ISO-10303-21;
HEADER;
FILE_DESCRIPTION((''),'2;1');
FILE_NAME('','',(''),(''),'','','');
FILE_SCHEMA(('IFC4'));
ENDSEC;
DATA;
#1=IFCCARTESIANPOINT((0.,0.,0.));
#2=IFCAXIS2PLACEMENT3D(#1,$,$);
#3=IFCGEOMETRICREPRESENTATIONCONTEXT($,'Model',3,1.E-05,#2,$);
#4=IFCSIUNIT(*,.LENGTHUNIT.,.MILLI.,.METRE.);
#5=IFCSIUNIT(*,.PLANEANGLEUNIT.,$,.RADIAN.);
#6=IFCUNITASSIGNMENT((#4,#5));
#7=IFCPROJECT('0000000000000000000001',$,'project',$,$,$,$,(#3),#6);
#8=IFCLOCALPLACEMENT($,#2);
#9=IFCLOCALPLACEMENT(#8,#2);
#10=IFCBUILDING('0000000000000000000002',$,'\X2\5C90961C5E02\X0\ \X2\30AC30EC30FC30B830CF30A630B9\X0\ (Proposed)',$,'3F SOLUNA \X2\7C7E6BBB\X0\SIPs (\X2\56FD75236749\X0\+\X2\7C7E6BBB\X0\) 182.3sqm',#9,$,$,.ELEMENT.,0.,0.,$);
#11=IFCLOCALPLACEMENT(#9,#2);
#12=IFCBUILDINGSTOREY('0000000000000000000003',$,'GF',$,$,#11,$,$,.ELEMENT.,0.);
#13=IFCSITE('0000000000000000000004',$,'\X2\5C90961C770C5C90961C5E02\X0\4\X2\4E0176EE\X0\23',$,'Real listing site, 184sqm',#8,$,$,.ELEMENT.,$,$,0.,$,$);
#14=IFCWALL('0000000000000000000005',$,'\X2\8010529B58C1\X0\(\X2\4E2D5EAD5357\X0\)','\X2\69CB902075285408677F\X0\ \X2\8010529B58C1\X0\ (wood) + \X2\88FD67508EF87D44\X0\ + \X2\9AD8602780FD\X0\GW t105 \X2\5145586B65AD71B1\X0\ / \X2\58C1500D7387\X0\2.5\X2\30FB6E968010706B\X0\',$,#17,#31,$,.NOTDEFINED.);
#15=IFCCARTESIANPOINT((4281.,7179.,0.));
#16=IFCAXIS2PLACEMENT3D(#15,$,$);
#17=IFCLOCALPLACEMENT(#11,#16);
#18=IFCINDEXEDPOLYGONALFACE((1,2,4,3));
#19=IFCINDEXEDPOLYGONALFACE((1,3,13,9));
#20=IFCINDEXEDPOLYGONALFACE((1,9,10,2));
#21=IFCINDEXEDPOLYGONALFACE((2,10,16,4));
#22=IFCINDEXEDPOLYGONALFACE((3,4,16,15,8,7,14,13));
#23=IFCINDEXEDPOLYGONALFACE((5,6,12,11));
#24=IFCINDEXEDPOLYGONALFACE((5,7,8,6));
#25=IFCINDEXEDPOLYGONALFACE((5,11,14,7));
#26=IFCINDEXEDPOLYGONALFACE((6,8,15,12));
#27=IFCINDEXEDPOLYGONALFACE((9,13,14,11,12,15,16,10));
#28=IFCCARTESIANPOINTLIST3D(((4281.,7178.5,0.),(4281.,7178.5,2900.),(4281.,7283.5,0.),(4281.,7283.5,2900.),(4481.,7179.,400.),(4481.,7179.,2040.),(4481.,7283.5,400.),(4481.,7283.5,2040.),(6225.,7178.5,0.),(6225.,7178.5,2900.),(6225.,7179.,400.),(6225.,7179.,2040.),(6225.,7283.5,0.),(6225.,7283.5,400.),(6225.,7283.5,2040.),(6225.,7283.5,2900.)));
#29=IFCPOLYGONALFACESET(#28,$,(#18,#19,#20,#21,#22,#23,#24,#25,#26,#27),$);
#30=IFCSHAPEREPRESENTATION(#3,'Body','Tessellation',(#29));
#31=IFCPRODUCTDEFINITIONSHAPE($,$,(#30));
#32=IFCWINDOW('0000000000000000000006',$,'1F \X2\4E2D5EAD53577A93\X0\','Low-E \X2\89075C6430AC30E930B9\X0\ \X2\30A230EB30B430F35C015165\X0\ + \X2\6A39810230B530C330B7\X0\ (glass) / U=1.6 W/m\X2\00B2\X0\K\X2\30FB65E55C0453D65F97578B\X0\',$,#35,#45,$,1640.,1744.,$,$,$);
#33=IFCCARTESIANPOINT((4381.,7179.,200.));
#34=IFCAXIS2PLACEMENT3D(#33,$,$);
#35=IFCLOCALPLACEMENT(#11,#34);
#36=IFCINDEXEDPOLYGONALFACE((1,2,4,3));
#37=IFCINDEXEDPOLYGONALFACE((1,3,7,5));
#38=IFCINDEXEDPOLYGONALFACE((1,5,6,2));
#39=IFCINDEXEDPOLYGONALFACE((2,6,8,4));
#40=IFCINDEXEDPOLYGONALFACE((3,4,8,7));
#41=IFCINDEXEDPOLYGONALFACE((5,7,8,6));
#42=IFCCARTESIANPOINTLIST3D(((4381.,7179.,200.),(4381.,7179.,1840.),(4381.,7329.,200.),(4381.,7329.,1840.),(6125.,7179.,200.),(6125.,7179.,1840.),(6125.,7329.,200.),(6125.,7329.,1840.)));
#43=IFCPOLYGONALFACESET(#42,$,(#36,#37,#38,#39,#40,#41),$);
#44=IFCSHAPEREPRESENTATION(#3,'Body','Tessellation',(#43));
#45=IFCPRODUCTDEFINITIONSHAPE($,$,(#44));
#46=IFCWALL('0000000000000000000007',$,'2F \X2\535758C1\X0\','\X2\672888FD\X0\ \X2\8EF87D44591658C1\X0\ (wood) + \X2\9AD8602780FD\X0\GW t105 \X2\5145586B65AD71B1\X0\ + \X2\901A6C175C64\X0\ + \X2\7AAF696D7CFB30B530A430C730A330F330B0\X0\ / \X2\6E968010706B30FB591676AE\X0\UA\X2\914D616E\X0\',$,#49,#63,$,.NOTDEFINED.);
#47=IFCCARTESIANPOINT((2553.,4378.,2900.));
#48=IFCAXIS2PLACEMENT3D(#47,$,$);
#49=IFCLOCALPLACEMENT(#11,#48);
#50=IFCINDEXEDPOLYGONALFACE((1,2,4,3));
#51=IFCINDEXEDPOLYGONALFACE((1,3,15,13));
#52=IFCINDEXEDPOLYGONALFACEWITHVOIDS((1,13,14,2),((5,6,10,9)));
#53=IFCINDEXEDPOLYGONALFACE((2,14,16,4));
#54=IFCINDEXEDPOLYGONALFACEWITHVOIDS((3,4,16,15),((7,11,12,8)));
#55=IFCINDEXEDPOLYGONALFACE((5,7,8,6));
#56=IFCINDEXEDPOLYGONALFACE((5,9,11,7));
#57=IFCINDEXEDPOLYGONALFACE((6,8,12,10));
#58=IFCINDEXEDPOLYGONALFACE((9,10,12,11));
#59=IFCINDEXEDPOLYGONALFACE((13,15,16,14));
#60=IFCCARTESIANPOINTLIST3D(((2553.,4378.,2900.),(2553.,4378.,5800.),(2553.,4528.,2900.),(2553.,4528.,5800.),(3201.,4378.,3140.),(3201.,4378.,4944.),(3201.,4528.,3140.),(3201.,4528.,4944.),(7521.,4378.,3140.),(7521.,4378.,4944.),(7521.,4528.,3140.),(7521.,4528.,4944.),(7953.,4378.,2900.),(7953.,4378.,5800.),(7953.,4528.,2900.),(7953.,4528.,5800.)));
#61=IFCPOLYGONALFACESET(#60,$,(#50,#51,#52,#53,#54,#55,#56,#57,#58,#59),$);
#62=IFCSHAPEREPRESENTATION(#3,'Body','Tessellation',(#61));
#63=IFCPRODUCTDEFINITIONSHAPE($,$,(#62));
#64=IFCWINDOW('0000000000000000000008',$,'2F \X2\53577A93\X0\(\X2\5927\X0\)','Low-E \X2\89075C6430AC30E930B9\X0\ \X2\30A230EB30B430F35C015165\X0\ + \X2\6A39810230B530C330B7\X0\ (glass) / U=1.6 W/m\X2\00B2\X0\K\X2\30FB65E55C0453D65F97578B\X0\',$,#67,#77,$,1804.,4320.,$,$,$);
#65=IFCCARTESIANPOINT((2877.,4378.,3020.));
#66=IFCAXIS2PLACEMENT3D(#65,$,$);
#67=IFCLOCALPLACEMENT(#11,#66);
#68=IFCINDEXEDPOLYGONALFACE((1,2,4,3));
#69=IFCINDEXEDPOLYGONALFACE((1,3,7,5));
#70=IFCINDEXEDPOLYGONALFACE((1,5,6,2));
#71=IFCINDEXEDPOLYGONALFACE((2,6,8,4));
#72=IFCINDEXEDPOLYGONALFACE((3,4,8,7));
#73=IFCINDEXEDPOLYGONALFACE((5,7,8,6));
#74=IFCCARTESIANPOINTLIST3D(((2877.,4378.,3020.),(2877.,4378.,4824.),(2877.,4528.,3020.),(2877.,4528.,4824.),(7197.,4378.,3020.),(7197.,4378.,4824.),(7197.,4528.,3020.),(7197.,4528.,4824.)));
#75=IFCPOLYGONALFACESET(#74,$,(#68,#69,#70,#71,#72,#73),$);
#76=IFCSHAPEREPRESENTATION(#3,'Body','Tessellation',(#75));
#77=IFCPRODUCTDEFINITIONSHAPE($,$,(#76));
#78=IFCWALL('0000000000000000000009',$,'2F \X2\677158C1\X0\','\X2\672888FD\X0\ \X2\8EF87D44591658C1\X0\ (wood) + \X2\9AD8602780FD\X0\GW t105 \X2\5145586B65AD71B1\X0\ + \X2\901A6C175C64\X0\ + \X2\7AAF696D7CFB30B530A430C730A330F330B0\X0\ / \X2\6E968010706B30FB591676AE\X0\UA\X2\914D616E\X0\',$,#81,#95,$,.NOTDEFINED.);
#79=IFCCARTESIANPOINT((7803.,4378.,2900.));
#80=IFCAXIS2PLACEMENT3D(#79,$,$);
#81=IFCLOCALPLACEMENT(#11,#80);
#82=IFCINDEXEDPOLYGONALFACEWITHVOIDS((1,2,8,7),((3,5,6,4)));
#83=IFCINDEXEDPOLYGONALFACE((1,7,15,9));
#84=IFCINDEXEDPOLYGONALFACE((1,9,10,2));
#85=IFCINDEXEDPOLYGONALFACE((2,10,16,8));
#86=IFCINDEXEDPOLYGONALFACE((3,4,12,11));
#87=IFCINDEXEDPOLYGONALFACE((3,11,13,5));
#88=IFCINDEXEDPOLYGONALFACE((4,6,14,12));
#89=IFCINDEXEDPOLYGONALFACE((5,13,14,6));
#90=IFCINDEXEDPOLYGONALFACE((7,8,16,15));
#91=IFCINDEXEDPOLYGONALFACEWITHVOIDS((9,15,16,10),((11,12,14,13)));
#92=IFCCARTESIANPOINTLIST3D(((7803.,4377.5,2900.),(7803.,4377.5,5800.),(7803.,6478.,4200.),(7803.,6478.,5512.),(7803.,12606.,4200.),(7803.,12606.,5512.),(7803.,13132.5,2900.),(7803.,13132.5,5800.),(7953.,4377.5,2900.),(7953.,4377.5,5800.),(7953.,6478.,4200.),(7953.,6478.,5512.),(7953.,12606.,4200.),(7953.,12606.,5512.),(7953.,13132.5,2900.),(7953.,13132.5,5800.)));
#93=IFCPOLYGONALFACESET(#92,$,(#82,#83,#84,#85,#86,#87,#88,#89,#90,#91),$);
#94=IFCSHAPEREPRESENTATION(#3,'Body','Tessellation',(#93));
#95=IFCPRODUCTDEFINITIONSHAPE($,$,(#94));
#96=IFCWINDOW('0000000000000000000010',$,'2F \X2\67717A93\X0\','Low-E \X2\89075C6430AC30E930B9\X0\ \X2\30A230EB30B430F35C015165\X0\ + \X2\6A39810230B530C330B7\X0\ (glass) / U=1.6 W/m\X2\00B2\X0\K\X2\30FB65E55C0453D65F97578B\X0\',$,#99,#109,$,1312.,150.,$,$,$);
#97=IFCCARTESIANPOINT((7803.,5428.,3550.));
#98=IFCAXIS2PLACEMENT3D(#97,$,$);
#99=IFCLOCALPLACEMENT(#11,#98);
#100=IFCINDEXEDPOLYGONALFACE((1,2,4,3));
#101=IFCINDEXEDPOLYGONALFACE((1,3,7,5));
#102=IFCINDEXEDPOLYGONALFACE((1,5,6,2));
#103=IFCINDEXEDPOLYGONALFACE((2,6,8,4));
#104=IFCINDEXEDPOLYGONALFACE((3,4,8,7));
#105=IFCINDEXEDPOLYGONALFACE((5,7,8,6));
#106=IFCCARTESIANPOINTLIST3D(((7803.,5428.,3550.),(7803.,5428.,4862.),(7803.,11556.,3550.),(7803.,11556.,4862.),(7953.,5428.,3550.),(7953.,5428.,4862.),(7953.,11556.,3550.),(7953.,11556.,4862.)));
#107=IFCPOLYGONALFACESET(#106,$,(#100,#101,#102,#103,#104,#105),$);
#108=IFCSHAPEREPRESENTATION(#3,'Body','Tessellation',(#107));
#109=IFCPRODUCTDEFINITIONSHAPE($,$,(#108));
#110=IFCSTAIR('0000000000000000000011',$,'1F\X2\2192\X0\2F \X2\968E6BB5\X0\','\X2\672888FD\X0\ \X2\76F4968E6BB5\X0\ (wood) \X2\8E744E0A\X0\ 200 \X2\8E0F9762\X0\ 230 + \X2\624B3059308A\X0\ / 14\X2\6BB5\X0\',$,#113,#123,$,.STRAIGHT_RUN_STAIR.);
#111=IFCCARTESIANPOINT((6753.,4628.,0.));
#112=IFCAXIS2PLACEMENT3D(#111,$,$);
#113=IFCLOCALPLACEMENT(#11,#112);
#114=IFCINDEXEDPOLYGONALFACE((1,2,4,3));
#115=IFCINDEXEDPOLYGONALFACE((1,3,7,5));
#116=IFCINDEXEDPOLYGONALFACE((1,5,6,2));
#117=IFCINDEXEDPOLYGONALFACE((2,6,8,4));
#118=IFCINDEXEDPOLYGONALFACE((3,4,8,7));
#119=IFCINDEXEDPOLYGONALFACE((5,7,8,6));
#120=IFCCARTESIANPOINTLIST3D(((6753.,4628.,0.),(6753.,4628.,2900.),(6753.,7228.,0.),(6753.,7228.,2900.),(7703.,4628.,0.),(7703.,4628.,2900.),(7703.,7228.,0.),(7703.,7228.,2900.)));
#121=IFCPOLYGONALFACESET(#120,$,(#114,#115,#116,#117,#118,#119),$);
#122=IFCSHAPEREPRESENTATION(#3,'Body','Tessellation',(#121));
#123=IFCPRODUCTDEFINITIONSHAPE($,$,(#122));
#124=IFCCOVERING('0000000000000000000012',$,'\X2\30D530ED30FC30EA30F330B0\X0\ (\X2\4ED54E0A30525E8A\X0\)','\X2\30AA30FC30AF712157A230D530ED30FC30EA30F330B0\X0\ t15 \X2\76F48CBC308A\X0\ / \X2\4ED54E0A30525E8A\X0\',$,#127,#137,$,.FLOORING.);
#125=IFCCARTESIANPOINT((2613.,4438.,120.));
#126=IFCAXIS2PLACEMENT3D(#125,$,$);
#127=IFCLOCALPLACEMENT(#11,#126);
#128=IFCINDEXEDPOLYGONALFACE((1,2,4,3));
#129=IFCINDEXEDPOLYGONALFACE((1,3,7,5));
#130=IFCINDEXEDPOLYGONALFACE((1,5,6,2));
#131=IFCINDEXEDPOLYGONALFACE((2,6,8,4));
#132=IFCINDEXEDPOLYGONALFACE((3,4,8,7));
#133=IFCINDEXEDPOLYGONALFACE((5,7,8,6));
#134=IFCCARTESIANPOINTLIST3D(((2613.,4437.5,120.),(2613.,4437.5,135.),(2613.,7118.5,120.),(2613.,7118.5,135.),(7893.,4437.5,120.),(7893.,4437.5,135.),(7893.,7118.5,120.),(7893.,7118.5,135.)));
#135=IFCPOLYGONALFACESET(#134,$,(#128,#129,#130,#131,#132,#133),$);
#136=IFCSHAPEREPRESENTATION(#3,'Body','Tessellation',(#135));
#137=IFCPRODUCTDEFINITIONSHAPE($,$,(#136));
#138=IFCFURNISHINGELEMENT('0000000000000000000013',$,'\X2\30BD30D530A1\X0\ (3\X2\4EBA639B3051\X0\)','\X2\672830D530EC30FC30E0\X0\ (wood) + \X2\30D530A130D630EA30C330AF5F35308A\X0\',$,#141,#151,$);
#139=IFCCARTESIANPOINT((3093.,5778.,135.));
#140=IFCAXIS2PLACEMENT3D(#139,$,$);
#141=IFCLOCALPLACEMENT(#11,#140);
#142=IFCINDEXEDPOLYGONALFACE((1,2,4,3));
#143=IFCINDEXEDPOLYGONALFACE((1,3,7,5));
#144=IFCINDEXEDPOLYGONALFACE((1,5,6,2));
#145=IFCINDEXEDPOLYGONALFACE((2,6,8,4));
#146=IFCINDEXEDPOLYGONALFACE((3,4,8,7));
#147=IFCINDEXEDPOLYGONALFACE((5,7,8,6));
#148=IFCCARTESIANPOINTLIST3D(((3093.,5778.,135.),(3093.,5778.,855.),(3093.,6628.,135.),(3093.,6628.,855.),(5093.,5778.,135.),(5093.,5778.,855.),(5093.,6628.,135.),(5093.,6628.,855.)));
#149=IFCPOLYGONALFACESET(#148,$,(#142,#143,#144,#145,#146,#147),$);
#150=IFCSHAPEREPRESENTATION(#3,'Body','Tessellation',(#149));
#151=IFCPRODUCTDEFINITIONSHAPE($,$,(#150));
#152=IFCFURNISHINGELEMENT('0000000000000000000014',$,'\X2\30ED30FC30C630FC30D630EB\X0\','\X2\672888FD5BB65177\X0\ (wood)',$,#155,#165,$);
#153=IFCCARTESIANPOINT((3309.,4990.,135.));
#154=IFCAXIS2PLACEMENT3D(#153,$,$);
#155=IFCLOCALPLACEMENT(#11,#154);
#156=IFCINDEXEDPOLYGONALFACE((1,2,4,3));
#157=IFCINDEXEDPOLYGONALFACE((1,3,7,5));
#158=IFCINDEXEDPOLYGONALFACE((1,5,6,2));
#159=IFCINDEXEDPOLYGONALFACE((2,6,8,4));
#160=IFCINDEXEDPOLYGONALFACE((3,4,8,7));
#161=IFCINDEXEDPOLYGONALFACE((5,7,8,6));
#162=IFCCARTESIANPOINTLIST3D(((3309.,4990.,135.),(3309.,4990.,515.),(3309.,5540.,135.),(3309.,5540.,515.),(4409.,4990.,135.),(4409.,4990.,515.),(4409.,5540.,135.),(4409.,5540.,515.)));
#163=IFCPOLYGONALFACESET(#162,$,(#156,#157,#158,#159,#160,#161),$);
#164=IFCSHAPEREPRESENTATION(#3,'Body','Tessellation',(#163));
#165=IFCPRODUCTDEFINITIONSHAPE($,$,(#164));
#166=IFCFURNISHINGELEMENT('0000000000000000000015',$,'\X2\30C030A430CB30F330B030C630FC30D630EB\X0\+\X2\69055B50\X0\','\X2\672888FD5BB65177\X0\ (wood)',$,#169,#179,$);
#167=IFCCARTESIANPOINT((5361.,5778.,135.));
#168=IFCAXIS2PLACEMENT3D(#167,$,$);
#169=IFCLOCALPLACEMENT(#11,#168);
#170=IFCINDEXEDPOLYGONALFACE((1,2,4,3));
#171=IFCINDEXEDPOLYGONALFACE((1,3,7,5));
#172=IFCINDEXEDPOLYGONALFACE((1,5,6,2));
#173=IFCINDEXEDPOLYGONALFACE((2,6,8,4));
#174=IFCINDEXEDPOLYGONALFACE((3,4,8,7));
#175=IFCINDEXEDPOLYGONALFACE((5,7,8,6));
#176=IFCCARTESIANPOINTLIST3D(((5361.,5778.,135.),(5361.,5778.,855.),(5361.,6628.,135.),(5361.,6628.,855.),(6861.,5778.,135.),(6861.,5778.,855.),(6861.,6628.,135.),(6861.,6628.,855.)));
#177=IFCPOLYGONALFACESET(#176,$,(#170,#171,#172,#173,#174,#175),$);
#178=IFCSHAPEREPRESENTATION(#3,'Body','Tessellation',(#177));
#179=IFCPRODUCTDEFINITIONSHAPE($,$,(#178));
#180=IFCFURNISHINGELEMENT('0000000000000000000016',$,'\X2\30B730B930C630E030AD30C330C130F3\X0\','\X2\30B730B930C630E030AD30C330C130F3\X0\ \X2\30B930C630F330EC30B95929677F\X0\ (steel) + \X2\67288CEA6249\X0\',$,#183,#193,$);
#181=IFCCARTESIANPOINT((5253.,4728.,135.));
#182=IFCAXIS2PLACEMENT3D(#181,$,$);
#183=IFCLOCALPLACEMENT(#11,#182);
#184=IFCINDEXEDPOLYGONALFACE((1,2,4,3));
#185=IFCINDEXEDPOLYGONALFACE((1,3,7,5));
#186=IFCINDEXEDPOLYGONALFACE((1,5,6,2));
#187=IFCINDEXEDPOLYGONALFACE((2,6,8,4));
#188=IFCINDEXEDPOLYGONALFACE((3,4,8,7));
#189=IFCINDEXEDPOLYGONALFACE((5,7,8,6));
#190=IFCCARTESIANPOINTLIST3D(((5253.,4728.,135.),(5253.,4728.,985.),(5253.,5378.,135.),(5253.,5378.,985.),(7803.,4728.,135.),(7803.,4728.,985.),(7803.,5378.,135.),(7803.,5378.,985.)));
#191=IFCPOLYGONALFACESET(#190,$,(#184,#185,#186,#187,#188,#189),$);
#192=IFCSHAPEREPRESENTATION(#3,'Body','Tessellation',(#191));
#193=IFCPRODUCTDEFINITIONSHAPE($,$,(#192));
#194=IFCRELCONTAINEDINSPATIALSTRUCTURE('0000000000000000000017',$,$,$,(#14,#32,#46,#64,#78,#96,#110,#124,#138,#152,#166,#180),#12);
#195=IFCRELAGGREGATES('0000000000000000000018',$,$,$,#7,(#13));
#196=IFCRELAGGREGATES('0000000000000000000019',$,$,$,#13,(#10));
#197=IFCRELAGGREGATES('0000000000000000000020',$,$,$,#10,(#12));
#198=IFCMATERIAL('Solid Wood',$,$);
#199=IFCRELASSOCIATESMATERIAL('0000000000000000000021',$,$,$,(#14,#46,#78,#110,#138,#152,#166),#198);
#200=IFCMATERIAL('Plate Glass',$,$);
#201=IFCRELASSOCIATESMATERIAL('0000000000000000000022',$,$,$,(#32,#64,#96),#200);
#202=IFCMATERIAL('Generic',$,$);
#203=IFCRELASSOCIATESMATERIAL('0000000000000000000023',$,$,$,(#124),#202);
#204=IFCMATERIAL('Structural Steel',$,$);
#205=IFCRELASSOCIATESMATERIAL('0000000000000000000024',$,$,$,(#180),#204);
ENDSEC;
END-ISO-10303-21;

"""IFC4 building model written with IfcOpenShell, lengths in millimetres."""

from ifc_helpers import new_model, si_unit, frame, frame_2d, origin, place, context, project, spatial, rectangle, extrude, material, element, fill, save


model = new_model("IFC4")

# Units and contexts
model_context = context("Model", 3, precision=1e-05, world=origin())
ifc_project = project(units=[si_unit("LENGTHUNIT", "METRE", prefix="MILLI"), si_unit("PLANEANGLEUNIT", "RADIAN")], contexts=[model_context])

# Site, building, storey
site_placement = place(None, origin())
site = spatial("IfcSite", under=ifc_project, at=site_placement, Name="岐阜県岐阜市4丁目23", ObjectType="Real listing site, 184sqm", CompositionType="ELEMENT", RefElevation=0.0)
building_placement = place(site_placement, origin())
building = spatial("IfcBuilding", under=site, at=building_placement, Name="岐阜市 ガレージハウス (Proposed)", ObjectType="3F SOLUNA 籾殻SIPs (国産杉+籾殻) 182.3sqm", CompositionType="ELEMENT", ElevationOfRefHeight=0.0, ElevationOfTerrain=0.0)
storey_placement = place(building_placement, origin())
storey = spatial("IfcBuildingStorey", under=building, at=storey_placement, Name="GF", CompositionType="ELEMENT", Elevation=0.0)

# Shared definitions
ifc_material_1 = material(Name="Solid Wood")
ifc_material_2 = material(Name="Generic")

# Shared definitions
ifc_material_3 = material(Name="Plate Glass")

# Wall, opening, window
wall_1_placement = place(storey_placement, frame((4281.0, 7179.0, 0.0)))
wall_1 = element("IfcWall", 1, at=wall_1_placement, inside=storey, material=ifc_material_1, Name="耐力壁(中庭南)", Description="構造用合板 耐力壁 (wood) + 製材軸組 + 高性能GW t105 充填断熱 / 壁倍率2.5・準耐火", PredefinedType="NOTDEFINED", context=model_context, shape_type="SweptSolid", body=[
    extrude(rectangle(XDim=1944.0, YDim=105.0, at=frame_2d((972.0, 52.0))), frame((4281.0, 7179.0, 0.0)), (0.0, 0.0, 1.0), 2900.0),
])
opening_1_placement = place(storey_placement, frame((4381.0, 7179.0, 200.0)))
opening_1 = element("IfcOpeningElement", 2, at=opening_1_placement, cuts=wall_1, PredefinedType="NOTDEFINED", context=model_context, shape_type="SweptSolid", body=[
    extrude(rectangle(XDim=1744.0, YDim=150.0, at=frame_2d((872.0, 75.0))), frame((4381.0, 7179.0, 200.0)), (0.0, 0.0, 1.0), 1640.0),
])
window_1_placement = place(storey_placement, frame((4381.0, 7179.0, 200.0)))
window_1 = element("IfcWindow", 3, at=window_1_placement, inside=storey, material=ifc_material_3, Name="1F 中庭南窓", Description="Low-E 複層ガラス アルゴン封入 + 樹脂サッシ (glass) / U=1.6 W/m²K・日射取得型", OverallHeight=1640.0, OverallWidth=1744.0, context=model_context, shape_type="SweptSolid", body=[
    extrude(rectangle(XDim=1744.0, YDim=150.0, at=frame_2d((872.0, 75.0))), frame((4381.0, 7179.0, 200.0)), (0.0, 0.0, 1.0), 1640.0),
])
fill(opening_1, window_1)

# Walls, openings, windows
wall_2_placement = place(storey_placement, frame((2553.0, 4378.0, 2900.0)))
wall_2 = element("IfcWall", 4, at=wall_2_placement, inside=storey, material=ifc_material_1, Name="2F 南壁", Description="木製 軸組外壁 (wood) + 高性能GW t105 充填断熱 + 通気層 + 窯業系サイディング / 準耐火・外皮UA配慮", PredefinedType="NOTDEFINED", context=model_context, shape_type="SweptSolid", body=[
    extrude(rectangle(XDim=5400.0, YDim=150.0, at=frame_2d((2700.0, 75.0))), frame((2553.0, 4378.0, 2900.0)), (0.0, 0.0, 1.0), 2900.0),
])
opening_2_placement = place(storey_placement, frame((2877.0, 4378.0, 3020.0)))
opening_2 = element("IfcOpeningElement", 5, at=opening_2_placement, cuts=wall_2, PredefinedType="NOTDEFINED", context=model_context, shape_type="SweptSolid", body=[
    extrude(rectangle(XDim=4320.0, YDim=150.0, at=frame_2d((2160.0, 75.0))), frame((2877.0, 4378.0, 3020.0)), (0.0, 0.0, 1.0), 1804.0),
])
window_2_placement = place(storey_placement, frame((2877.0, 4378.0, 3020.0)))
window_2 = element("IfcWindow", 6, at=window_2_placement, inside=storey, material=ifc_material_3, Name="2F 南窓(大)", Description="Low-E 複層ガラス アルゴン封入 + 樹脂サッシ (glass) / U=1.6 W/m²K・日射取得型", OverallHeight=1804.0, OverallWidth=4320.0, context=model_context, shape_type="SweptSolid", body=[
    extrude(rectangle(XDim=4320.0, YDim=150.0, at=frame_2d((2160.0, 75.0))), frame((2877.0, 4378.0, 3020.0)), (0.0, 0.0, 1.0), 1804.0),
])
fill(opening_2, window_2)
wall_3_placement = place(storey_placement, frame((7803.0, 4378.0, 2900.0)))
wall_3 = element("IfcWall", 7, at=wall_3_placement, inside=storey, material=ifc_material_1, Name="2F 東壁", Description="木製 軸組外壁 (wood) + 高性能GW t105 充填断熱 + 通気層 + 窯業系サイディング / 準耐火・外皮UA配慮", PredefinedType="NOTDEFINED", context=model_context, shape_type="SweptSolid", body=[
    extrude(rectangle(XDim=150.0, YDim=8755.0, at=frame_2d((75.0, 4377.0))), frame((7803.0, 4378.0, 2900.0)), (0.0, 0.0, 1.0), 2900.0),
])
opening_3_placement = place(storey_placement, frame((7803.0, 5428.0, 3550.0)))
opening_3 = element("IfcOpeningElement", 8, at=opening_3_placement, cuts=wall_3, PredefinedType="NOTDEFINED", context=model_context, shape_type="SweptSolid", body=[
    extrude(rectangle(XDim=150.0, YDim=6128.0, at=frame_2d((75.0, 3064.0))), frame((7803.0, 5428.0, 3550.0)), (0.0, 0.0, 1.0), 1312.0),
])
window_3_placement = place(storey_placement, frame((7803.0, 5428.0, 3550.0)))
window_3 = element("IfcWindow", 9, at=window_3_placement, inside=storey, material=ifc_material_3, Name="2F 東窓", Description="Low-E 複層ガラス アルゴン封入 + 樹脂サッシ (glass) / U=1.6 W/m²K・日射取得型", OverallHeight=1312.0, OverallWidth=150.0, context=model_context, shape_type="SweptSolid", body=[
    extrude(rectangle(XDim=150.0, YDim=6128.0, at=frame_2d((75.0, 3064.0))), frame((7803.0, 5428.0, 3550.0)), (0.0, 0.0, 1.0), 1312.0),
])
fill(opening_3, window_3)

# Stair
stair_placement = place(storey_placement, frame((6753.0, 4628.0, 0.0)))
element("IfcStair", 10, at=stair_placement, inside=storey, material=ifc_material_1, Name="1F→2F 階段", Description="木製 直階段 (wood) 蹴上 200 踏面 230 + 手すり / 14段", PredefinedType="STRAIGHT_RUN_STAIR", context=model_context, shape_type="SweptSolid", body=[
    extrude(rectangle(XDim=950.0, YDim=2600.0, at=frame_2d((475.0, 1300.0))), frame((6753.0, 4628.0, 0.0)), (0.0, 0.0, 1.0), 2900.0),
])

# Covering
covering_placement = place(storey_placement, frame((2613.0, 4438.0, 120.0)))
element("IfcCovering", 11, at=covering_placement, inside=storey, material=ifc_material_2, Name="フローリング (仕上げ床)", Description="オーク無垢フローリング t15 直貼り / 仕上げ床", PredefinedType="FLOORING", context=model_context, shape_type="SweptSolid", body=[
    extrude(rectangle(XDim=5280.0, YDim=2681.0, at=frame_2d((2640.0, 1340.0))), frame((2613.0, 4438.0, 120.0)), (0.0, 0.0, 1.0), 15.0),
])

# Furnishing elements
furnishing_1_placement = place(storey_placement, frame((3093.0, 5778.0, 135.0)))
element("IfcFurnishingElement", 12, at=furnishing_1_placement, inside=storey, material=ifc_material_1, Name="ソファ (3人掛け)", Description="木フレーム (wood) + ファブリック張り", context=model_context, shape_type="SweptSolid", body=[
    extrude(rectangle(XDim=2000.0, YDim=850.0, at=frame_2d((1000.0, 425.0))), frame((3093.0, 5778.0, 135.0)), (0.0, 0.0, 1.0), 720.0),
])
furnishing_2_placement = place(storey_placement, frame((3309.0, 4990.0, 135.0)))
element("IfcFurnishingElement", 13, at=furnishing_2_placement, inside=storey, material=ifc_material_1, Name="ローテーブル", Description="木製家具 (wood)", context=model_context, shape_type="SweptSolid", body=[
    extrude(rectangle(XDim=1100.0, YDim=550.0, at=frame_2d((550.0, 275.0))), frame((3309.0, 4990.0, 135.0)), (0.0, 0.0, 1.0), 380.0),
])
furnishing_3_placement = place(storey_placement, frame((5361.0, 5778.0, 135.0)))
element("IfcFurnishingElement", 14, at=furnishing_3_placement, inside=storey, material=ifc_material_1, Name="ダイニングテーブル+椅子", Description="木製家具 (wood)", context=model_context, shape_type="SweptSolid", body=[
    extrude(rectangle(XDim=1500.0, YDim=850.0, at=frame_2d((750.0, 425.0))), frame((5361.0, 5778.0, 135.0)), (0.0, 0.0, 1.0), 720.0),
])
ifc_material_4 = material(Name="Structural Steel")
furnishing_4_placement = place(storey_placement, frame((5253.0, 4728.0, 135.0)))
element("IfcFurnishingElement", 15, at=furnishing_4_placement, inside=storey, material=ifc_material_4, Name="システムキッチン", Description="システムキッチン ステンレス天板 (steel) + 木質扉", context=model_context, shape_type="SweptSolid", body=[
    extrude(rectangle(XDim=2550.0, YDim=650.0, at=frame_2d((1275.0, 325.0))), frame((5253.0, 4728.0, 135.0)), (0.0, 0.0, 1.0), 850.0),
])

save(model, "model.ifc")
